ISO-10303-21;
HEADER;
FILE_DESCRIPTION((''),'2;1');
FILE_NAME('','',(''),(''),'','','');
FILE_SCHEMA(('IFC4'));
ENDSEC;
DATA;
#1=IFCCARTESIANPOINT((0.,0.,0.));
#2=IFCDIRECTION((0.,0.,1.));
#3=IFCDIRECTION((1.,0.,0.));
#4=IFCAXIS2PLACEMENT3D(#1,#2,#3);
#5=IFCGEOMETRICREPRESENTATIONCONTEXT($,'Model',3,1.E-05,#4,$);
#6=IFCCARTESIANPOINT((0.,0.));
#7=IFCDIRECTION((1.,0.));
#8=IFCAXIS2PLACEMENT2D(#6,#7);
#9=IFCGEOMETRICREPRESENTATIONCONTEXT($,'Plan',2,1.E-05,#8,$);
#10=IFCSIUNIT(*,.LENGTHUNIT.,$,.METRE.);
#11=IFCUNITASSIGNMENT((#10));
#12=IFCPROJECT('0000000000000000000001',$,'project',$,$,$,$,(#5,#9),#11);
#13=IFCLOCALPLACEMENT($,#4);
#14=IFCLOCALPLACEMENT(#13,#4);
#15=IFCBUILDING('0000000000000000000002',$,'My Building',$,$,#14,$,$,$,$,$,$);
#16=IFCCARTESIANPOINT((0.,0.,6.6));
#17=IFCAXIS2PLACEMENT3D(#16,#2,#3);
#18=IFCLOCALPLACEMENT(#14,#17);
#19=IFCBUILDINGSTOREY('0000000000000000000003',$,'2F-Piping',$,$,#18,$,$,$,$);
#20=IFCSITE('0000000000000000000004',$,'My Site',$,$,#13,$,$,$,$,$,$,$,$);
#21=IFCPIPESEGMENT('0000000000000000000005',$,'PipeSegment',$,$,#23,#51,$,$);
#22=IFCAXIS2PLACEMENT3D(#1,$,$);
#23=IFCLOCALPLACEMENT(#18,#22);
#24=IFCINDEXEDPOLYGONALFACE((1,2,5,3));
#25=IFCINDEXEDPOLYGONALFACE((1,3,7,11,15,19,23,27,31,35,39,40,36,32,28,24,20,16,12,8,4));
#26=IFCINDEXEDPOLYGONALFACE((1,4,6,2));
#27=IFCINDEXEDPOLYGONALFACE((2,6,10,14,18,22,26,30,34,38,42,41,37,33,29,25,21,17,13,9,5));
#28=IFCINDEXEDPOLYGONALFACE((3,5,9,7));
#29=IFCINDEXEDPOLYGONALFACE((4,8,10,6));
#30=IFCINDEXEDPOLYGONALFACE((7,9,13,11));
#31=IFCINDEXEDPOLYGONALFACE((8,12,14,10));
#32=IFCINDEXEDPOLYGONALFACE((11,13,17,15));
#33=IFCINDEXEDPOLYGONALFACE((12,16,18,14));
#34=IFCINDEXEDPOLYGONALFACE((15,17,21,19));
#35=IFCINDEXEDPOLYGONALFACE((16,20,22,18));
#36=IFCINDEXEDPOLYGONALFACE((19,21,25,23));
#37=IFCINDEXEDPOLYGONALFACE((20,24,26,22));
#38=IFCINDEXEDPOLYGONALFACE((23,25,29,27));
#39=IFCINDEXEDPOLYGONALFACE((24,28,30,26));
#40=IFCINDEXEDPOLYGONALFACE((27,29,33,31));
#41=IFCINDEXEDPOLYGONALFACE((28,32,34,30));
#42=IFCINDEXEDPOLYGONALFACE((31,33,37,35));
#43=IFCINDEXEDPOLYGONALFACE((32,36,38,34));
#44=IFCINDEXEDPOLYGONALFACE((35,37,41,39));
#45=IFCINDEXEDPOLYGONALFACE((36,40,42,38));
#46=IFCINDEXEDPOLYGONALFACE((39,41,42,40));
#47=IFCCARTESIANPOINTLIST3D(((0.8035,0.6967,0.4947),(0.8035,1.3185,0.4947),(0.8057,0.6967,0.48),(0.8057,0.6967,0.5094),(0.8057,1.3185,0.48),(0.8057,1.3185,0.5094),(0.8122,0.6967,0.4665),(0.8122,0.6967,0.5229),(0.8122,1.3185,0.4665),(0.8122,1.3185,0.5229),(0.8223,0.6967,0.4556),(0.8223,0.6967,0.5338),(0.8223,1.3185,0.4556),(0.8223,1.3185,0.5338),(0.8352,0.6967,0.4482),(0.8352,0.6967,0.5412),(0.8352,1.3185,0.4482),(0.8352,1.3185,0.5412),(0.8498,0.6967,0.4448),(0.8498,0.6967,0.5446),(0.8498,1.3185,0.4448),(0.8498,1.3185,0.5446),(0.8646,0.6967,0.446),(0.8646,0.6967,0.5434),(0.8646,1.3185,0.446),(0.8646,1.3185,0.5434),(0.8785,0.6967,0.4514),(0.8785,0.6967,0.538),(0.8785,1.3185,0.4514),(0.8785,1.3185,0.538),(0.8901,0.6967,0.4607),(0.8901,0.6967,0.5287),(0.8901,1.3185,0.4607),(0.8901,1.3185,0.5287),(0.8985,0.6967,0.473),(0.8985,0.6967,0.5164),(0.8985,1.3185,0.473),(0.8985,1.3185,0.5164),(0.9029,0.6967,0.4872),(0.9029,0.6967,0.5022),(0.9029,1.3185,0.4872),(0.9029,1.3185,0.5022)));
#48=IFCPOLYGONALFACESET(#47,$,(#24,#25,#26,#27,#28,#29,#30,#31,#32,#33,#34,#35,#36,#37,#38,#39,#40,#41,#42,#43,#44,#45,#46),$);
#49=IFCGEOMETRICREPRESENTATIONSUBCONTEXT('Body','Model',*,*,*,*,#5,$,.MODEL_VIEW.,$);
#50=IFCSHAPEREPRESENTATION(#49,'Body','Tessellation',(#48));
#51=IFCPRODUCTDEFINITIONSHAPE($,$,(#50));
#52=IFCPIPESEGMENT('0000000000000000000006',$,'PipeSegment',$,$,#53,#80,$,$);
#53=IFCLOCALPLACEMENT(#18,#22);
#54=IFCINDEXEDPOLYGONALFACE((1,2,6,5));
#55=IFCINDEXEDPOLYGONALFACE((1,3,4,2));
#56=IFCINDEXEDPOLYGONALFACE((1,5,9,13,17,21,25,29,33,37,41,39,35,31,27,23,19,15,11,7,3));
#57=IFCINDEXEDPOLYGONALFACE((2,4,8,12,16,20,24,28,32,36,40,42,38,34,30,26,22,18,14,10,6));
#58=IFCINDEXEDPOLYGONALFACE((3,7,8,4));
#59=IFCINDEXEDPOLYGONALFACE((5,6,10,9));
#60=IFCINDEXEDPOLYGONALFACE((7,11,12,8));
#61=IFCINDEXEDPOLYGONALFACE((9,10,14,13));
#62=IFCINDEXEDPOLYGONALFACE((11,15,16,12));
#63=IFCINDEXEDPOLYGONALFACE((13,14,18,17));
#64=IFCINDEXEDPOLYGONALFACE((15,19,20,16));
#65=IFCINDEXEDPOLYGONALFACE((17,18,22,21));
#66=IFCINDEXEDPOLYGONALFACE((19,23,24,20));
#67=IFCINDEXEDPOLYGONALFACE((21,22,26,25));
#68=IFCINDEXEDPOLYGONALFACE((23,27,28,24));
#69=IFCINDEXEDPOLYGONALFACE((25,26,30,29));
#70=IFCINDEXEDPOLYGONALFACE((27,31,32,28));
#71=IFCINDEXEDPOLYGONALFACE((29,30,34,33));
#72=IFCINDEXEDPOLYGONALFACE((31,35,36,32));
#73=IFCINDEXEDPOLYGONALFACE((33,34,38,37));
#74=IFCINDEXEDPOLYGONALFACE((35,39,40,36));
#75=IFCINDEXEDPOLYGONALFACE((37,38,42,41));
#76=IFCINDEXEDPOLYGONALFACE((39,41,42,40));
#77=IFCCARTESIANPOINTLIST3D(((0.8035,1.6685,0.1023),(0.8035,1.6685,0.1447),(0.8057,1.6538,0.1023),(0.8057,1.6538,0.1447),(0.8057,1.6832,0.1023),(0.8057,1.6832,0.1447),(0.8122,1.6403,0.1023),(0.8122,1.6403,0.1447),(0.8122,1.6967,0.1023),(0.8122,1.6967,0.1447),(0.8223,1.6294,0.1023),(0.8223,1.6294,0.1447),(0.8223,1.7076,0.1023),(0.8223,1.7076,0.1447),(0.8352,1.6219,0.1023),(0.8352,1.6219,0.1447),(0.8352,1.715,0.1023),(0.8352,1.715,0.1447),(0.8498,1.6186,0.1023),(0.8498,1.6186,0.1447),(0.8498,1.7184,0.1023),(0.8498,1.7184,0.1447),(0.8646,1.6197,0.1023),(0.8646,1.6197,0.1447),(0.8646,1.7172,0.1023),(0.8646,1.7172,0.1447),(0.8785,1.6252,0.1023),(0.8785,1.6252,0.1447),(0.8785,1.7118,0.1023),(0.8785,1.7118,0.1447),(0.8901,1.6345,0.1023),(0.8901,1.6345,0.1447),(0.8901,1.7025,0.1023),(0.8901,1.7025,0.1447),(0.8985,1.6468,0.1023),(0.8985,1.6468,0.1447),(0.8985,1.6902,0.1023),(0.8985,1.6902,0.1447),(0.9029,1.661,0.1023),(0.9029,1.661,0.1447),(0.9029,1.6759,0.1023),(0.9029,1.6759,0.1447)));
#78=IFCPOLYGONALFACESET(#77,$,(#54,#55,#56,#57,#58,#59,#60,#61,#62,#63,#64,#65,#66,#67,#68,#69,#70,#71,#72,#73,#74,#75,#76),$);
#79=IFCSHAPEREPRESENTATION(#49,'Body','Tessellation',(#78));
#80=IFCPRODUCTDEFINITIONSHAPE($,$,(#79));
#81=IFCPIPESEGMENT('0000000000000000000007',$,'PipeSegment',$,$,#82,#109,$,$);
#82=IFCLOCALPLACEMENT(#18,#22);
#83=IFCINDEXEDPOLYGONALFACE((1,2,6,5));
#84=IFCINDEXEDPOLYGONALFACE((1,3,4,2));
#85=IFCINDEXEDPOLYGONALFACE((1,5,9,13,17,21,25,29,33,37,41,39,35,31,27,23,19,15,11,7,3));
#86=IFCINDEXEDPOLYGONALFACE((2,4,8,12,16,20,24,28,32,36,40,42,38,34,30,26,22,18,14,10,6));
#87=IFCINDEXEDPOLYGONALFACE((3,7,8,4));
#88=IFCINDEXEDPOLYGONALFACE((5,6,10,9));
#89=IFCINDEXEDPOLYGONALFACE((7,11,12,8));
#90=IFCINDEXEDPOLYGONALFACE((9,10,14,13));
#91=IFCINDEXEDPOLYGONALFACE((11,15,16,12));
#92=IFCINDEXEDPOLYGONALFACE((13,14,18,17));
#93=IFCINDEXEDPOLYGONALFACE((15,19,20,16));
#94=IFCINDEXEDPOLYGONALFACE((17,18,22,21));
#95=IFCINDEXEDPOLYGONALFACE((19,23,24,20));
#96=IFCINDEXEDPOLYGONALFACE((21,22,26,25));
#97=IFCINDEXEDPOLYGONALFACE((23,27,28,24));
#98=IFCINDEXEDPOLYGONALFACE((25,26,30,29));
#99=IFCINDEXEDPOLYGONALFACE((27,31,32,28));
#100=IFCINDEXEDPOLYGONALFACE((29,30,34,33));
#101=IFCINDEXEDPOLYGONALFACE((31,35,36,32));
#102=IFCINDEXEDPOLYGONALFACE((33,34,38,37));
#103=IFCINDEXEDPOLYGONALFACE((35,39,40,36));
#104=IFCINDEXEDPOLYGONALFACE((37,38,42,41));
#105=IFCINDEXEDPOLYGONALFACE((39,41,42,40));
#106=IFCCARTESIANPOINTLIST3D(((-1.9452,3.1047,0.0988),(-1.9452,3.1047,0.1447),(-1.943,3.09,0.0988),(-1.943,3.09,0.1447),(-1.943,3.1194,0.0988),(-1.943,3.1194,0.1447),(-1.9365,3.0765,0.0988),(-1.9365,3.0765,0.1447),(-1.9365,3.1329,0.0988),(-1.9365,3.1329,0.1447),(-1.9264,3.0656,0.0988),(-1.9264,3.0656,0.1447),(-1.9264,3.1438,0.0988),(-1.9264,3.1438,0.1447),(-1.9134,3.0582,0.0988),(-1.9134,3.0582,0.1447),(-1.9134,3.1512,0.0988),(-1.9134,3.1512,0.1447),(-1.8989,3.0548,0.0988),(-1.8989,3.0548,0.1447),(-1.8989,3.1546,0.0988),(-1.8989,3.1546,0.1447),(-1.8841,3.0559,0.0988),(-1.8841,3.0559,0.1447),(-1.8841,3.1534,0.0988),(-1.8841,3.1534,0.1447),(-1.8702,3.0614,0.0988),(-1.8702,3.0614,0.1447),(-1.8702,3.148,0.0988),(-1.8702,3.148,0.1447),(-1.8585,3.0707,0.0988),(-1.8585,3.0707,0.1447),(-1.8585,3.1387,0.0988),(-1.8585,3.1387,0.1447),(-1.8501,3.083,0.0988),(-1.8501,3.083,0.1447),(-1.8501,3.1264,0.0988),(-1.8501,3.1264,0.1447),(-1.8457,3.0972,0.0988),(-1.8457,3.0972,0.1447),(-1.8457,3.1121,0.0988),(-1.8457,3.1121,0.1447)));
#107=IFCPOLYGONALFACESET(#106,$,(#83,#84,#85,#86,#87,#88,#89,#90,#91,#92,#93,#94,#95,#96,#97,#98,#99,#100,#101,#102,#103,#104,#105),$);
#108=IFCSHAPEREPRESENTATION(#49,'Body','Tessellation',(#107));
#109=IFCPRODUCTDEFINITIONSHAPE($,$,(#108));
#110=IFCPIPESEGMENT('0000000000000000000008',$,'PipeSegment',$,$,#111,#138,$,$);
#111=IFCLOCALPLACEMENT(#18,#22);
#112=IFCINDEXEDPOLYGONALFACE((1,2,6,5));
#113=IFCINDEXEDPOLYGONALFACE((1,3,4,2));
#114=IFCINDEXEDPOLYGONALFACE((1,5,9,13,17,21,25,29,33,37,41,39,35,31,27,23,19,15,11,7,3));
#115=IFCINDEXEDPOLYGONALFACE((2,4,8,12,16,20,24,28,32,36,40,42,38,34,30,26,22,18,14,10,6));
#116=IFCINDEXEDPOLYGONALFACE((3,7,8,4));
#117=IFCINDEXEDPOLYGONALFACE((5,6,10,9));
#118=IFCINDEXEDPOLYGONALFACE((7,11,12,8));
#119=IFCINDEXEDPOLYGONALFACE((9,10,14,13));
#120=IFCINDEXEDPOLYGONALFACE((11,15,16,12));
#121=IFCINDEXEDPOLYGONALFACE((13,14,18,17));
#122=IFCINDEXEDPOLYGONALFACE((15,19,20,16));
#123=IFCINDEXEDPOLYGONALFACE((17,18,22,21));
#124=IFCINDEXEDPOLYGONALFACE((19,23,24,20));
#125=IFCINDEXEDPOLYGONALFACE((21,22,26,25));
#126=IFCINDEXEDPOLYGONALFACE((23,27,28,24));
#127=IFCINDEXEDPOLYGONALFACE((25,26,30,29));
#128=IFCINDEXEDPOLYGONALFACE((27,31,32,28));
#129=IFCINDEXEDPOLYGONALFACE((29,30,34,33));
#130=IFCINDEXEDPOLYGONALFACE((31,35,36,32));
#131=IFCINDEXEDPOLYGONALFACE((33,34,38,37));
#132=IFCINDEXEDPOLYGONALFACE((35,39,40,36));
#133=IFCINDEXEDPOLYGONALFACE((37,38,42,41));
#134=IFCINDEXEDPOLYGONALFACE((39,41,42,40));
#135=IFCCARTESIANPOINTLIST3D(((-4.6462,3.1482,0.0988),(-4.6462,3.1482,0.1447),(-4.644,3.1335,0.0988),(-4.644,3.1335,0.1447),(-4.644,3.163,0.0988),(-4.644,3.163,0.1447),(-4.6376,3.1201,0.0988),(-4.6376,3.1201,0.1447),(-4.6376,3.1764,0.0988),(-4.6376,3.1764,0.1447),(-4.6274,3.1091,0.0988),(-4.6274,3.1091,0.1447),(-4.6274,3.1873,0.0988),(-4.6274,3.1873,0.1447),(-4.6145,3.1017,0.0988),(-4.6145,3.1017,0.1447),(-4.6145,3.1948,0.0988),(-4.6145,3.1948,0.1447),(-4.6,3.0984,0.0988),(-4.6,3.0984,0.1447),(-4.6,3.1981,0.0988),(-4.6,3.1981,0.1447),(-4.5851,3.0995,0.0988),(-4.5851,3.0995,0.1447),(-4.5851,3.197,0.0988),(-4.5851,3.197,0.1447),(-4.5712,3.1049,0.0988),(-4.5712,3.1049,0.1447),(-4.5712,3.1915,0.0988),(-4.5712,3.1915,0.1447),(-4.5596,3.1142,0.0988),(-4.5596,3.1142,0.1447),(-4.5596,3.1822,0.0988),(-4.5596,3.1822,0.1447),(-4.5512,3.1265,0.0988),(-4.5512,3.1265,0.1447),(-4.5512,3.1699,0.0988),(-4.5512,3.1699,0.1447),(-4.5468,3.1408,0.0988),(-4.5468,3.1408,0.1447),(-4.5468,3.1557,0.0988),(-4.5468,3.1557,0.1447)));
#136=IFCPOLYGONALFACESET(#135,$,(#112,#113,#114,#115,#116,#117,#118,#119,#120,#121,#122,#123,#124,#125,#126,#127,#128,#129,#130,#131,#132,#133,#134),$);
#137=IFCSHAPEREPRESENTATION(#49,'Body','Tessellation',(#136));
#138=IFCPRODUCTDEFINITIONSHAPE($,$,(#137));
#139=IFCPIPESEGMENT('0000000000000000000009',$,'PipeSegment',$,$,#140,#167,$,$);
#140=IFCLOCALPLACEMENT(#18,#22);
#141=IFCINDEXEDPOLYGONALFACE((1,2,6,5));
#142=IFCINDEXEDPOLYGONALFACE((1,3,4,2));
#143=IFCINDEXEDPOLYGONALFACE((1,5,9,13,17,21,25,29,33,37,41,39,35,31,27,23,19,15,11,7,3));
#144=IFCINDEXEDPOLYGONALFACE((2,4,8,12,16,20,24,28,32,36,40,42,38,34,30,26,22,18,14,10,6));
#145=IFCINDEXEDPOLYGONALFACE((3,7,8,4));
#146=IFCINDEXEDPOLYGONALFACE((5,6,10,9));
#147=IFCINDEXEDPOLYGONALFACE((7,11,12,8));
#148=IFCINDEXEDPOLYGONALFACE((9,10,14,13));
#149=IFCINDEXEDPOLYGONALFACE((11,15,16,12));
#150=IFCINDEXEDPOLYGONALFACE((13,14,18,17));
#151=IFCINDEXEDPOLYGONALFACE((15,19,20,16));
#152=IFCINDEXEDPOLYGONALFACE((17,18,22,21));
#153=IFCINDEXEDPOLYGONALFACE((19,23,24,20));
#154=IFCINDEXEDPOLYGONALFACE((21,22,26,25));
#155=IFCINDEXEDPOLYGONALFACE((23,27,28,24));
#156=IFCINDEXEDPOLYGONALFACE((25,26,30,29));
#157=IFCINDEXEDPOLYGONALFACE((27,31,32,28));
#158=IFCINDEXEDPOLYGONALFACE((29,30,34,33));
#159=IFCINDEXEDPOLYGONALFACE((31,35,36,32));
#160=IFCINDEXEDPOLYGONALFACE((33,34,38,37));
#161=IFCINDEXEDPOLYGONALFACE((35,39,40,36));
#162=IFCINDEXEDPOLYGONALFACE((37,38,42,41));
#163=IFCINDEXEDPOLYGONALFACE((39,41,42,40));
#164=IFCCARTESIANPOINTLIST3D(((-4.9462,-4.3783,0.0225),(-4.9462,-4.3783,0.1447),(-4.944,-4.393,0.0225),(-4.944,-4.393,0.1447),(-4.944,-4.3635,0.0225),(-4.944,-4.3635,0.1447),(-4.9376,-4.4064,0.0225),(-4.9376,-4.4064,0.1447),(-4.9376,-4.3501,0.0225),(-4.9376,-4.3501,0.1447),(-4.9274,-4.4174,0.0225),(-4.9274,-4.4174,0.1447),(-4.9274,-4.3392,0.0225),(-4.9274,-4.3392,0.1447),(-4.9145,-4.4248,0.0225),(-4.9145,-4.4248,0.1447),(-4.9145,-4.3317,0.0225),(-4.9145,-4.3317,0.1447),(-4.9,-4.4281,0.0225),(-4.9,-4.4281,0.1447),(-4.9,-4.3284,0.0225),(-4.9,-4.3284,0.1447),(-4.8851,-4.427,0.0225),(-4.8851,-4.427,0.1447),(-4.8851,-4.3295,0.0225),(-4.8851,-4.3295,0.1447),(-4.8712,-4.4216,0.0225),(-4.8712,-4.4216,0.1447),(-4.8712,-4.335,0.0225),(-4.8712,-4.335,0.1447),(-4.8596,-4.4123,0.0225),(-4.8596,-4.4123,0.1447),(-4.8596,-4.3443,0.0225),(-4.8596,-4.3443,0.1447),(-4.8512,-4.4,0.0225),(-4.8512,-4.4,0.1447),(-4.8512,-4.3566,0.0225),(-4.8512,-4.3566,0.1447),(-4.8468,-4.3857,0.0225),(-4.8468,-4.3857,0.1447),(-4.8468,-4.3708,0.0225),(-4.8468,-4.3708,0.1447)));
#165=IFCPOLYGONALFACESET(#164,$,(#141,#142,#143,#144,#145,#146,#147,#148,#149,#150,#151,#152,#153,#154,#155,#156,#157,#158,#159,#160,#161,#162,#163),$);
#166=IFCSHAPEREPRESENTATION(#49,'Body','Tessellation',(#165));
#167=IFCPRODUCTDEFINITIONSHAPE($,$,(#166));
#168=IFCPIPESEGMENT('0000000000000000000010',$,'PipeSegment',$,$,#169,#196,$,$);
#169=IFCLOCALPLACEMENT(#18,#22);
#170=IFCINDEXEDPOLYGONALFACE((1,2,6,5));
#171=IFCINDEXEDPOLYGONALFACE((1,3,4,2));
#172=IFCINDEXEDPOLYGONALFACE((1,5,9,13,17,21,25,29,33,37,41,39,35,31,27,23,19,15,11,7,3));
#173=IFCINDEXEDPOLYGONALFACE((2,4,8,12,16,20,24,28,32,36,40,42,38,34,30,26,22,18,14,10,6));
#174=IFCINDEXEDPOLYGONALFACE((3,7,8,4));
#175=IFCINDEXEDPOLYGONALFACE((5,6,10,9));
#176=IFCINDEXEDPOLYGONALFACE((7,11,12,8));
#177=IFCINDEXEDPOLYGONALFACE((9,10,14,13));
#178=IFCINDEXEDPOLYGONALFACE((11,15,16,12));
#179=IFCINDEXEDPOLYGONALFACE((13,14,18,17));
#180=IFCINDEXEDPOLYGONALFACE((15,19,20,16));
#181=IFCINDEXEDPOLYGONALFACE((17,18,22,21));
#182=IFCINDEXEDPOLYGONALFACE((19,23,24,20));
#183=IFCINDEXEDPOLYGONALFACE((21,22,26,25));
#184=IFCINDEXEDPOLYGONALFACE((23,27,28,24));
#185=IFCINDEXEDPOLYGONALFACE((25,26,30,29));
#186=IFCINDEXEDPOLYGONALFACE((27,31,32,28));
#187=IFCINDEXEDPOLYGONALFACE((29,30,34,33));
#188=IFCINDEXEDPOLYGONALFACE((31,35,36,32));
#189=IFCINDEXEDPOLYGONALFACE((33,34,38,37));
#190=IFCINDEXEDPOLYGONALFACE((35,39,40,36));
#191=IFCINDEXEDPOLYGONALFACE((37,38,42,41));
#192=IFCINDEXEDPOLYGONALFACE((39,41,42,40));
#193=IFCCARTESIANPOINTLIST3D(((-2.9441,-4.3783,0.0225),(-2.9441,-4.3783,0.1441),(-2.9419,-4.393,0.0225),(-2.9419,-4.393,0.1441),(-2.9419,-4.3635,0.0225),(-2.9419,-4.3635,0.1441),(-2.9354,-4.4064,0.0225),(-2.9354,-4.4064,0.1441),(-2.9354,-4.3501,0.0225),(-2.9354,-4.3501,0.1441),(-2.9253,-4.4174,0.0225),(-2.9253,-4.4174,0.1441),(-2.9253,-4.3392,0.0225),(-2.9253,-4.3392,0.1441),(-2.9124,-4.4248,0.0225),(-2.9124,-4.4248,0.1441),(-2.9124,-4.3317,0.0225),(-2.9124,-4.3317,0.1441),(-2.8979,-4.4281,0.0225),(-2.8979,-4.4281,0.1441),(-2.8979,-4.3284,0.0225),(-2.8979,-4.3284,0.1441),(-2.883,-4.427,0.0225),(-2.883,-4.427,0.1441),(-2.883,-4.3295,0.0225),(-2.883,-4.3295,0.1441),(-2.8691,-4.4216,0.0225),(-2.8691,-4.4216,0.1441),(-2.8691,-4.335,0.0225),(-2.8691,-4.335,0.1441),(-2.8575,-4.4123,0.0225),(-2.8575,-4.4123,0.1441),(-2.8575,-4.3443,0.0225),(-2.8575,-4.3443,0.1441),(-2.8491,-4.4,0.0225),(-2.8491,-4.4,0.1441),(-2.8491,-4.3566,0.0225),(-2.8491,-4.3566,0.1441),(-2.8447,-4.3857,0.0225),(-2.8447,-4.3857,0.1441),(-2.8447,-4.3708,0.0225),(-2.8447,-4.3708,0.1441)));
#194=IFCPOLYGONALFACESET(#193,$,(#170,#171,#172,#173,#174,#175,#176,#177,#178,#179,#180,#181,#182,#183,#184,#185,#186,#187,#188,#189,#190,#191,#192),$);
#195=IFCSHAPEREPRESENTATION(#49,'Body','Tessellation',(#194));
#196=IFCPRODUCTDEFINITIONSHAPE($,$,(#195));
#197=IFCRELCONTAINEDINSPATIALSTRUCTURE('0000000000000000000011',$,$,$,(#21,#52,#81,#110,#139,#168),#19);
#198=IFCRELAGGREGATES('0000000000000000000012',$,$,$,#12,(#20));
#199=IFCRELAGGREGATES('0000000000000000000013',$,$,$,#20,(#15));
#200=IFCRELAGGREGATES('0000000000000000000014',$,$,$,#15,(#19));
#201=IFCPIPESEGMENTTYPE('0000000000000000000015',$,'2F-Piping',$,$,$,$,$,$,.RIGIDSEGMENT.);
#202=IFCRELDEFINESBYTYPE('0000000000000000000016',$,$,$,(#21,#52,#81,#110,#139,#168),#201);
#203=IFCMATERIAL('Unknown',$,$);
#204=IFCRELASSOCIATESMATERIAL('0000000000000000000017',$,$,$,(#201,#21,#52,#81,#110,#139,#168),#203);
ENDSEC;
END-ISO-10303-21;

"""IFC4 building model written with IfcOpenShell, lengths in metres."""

from ifc_helpers import new_model, si_unit, frame, origin_with_axes, origin_2d_with_axis, place, context, subcontext, project, spatial, circle, extrude, material, material_profile, profile_set, profile_usage, type_object, element, save


model = new_model("IFC4")

# Units and contexts
model_context = context("Model", 3, precision=1e-05, world=origin_with_axes())
plan_context = context("Plan", 2, precision=1e-05, world=origin_2d_with_axis())
body_context = subcontext(model_context, "Body", "Model", "MODEL_VIEW")
ifc_project = project(units=[si_unit("LENGTHUNIT", "METRE")], contexts=[model_context, plan_context])

# Site, building, storey
site_placement = place(None, origin_with_axes())
site = spatial("IfcSite", under=ifc_project, at=site_placement, Name="My Site")
building_placement = place(site_placement, origin_with_axes())
building = spatial("IfcBuilding", under=site, at=building_placement, Name="My Building")
storey_placement = place(building_placement, frame((0.0, 0.0, 6.6), z_axis=(0.0, 0.0, 1.0), x_axis=(1.0, 0.0, 0.0)))
storey = spatial("IfcBuildingStorey", under=building, at=storey_placement, Name="2F-Piping")

# Pipe segments
ifc_material = material(Name="Unknown")
ifc_material_profile = material_profile(ifc_material, circle(Radius=0.05))
ifc_profile_set = profile_set([ifc_material_profile])
pipe_segment_type = type_object("IfcPipeSegmentType", Name="2F-Piping", PredefinedType="RIGIDSEGMENT", material=ifc_profile_set)
ifc_profile_usage_1 = profile_usage(ifc_profile_set, cardinal=5)
pipe_segment_1_placement = place(storey_placement, frame((0.8535, 0.6967, 0.4947), z_axis=(0.0, 1.0, 0.0), x_axis=(-1.0, 0.0, 0.0)))
element("IfcPipeSegment", 1, at=pipe_segment_1_placement, inside=storey, type_object=pipe_segment_type, material=ifc_profile_usage_1, Name="PipeSegment", context=body_context, shape_type="SweptSolid", body=[
    extrude(circle(Radius=0.05), origin_with_axes(), (0.0, 0.0, 1.0), 0.6218),
])
ifc_profile_usage_2 = profile_usage(ifc_profile_set, cardinal=5)
pipe_segment_2_placement = place(storey_placement, frame((0.8535, 1.6685, 0.1447), z_axis=(0.0, 0.0, -1.0), x_axis=(-1.0, 0.0, 0.0)))
element("IfcPipeSegment", 2, at=pipe_segment_2_placement, inside=storey, type_object=pipe_segment_type, material=ifc_profile_usage_2, Name="PipeSegment", context=body_context, shape_type="SweptSolid", body=[
    extrude(circle(Radius=0.05), origin_with_axes(), (0.0, 0.0, 1.0), 0.0424),
])
ifc_profile_usage_3 = profile_usage(ifc_profile_set, cardinal=5)
pipe_segment_3_placement = place(storey_placement, frame((-1.8952, 3.1047, 0.1447), z_axis=(0.0, 0.0, -1.0), x_axis=(-1.0, 0.0, 0.0)))
element("IfcPipeSegment", 3, at=pipe_segment_3_placement, inside=storey, type_object=pipe_segment_type, material=ifc_profile_usage_3, Name="PipeSegment", context=body_context, shape_type="SweptSolid", body=[
    extrude(circle(Radius=0.05), origin_with_axes(), (0.0, 0.0, 1.0), 0.0459),
])
ifc_profile_usage_4 = profile_usage(ifc_profile_set, cardinal=5)
pipe_segment_4_placement = place(storey_placement, frame((-4.5962, 3.1482, 0.1447), z_axis=(0.0, 0.0, -1.0), x_axis=(-1.0, 0.0, 0.0)))
element("IfcPipeSegment", 4, at=pipe_segment_4_placement, inside=storey, type_object=pipe_segment_type, material=ifc_profile_usage_4, Name="PipeSegment", context=body_context, shape_type="SweptSolid", body=[
    extrude(circle(Radius=0.05), origin_with_axes(), (0.0, 0.0, 1.0), 0.0459),
])
ifc_profile_usage_5 = profile_usage(ifc_profile_set, cardinal=5)
pipe_segment_5_placement = place(storey_placement, frame((-4.8962, -4.3783, 0.1447), z_axis=(0.0, 0.0, -1.0), x_axis=(-1.0, 0.0, 0.0)))
element("IfcPipeSegment", 5, at=pipe_segment_5_placement, inside=storey, type_object=pipe_segment_type, material=ifc_profile_usage_5, Name="PipeSegment", context=body_context, shape_type="SweptSolid", body=[
    extrude(circle(Radius=0.05), origin_with_axes(), (0.0, 0.0, 1.0), 0.1222),
])
ifc_profile_usage_6 = profile_usage(ifc_profile_set, cardinal=5)
pipe_segment_6_placement = place(storey_placement, frame((-2.8941, -4.3783, 0.1441), z_axis=(0.0, 0.0, -1.0), x_axis=(-1.0, 0.0, 0.0)))
element("IfcPipeSegment", 6, at=pipe_segment_6_placement, inside=storey, type_object=pipe_segment_type, material=ifc_profile_usage_6, Name="PipeSegment", context=body_context, shape_type="SweptSolid", body=[
    extrude(circle(Radius=0.05), origin_with_axes(), (0.0, 0.0, 1.0), 0.1217),
])

save(model, "model.ifc")
